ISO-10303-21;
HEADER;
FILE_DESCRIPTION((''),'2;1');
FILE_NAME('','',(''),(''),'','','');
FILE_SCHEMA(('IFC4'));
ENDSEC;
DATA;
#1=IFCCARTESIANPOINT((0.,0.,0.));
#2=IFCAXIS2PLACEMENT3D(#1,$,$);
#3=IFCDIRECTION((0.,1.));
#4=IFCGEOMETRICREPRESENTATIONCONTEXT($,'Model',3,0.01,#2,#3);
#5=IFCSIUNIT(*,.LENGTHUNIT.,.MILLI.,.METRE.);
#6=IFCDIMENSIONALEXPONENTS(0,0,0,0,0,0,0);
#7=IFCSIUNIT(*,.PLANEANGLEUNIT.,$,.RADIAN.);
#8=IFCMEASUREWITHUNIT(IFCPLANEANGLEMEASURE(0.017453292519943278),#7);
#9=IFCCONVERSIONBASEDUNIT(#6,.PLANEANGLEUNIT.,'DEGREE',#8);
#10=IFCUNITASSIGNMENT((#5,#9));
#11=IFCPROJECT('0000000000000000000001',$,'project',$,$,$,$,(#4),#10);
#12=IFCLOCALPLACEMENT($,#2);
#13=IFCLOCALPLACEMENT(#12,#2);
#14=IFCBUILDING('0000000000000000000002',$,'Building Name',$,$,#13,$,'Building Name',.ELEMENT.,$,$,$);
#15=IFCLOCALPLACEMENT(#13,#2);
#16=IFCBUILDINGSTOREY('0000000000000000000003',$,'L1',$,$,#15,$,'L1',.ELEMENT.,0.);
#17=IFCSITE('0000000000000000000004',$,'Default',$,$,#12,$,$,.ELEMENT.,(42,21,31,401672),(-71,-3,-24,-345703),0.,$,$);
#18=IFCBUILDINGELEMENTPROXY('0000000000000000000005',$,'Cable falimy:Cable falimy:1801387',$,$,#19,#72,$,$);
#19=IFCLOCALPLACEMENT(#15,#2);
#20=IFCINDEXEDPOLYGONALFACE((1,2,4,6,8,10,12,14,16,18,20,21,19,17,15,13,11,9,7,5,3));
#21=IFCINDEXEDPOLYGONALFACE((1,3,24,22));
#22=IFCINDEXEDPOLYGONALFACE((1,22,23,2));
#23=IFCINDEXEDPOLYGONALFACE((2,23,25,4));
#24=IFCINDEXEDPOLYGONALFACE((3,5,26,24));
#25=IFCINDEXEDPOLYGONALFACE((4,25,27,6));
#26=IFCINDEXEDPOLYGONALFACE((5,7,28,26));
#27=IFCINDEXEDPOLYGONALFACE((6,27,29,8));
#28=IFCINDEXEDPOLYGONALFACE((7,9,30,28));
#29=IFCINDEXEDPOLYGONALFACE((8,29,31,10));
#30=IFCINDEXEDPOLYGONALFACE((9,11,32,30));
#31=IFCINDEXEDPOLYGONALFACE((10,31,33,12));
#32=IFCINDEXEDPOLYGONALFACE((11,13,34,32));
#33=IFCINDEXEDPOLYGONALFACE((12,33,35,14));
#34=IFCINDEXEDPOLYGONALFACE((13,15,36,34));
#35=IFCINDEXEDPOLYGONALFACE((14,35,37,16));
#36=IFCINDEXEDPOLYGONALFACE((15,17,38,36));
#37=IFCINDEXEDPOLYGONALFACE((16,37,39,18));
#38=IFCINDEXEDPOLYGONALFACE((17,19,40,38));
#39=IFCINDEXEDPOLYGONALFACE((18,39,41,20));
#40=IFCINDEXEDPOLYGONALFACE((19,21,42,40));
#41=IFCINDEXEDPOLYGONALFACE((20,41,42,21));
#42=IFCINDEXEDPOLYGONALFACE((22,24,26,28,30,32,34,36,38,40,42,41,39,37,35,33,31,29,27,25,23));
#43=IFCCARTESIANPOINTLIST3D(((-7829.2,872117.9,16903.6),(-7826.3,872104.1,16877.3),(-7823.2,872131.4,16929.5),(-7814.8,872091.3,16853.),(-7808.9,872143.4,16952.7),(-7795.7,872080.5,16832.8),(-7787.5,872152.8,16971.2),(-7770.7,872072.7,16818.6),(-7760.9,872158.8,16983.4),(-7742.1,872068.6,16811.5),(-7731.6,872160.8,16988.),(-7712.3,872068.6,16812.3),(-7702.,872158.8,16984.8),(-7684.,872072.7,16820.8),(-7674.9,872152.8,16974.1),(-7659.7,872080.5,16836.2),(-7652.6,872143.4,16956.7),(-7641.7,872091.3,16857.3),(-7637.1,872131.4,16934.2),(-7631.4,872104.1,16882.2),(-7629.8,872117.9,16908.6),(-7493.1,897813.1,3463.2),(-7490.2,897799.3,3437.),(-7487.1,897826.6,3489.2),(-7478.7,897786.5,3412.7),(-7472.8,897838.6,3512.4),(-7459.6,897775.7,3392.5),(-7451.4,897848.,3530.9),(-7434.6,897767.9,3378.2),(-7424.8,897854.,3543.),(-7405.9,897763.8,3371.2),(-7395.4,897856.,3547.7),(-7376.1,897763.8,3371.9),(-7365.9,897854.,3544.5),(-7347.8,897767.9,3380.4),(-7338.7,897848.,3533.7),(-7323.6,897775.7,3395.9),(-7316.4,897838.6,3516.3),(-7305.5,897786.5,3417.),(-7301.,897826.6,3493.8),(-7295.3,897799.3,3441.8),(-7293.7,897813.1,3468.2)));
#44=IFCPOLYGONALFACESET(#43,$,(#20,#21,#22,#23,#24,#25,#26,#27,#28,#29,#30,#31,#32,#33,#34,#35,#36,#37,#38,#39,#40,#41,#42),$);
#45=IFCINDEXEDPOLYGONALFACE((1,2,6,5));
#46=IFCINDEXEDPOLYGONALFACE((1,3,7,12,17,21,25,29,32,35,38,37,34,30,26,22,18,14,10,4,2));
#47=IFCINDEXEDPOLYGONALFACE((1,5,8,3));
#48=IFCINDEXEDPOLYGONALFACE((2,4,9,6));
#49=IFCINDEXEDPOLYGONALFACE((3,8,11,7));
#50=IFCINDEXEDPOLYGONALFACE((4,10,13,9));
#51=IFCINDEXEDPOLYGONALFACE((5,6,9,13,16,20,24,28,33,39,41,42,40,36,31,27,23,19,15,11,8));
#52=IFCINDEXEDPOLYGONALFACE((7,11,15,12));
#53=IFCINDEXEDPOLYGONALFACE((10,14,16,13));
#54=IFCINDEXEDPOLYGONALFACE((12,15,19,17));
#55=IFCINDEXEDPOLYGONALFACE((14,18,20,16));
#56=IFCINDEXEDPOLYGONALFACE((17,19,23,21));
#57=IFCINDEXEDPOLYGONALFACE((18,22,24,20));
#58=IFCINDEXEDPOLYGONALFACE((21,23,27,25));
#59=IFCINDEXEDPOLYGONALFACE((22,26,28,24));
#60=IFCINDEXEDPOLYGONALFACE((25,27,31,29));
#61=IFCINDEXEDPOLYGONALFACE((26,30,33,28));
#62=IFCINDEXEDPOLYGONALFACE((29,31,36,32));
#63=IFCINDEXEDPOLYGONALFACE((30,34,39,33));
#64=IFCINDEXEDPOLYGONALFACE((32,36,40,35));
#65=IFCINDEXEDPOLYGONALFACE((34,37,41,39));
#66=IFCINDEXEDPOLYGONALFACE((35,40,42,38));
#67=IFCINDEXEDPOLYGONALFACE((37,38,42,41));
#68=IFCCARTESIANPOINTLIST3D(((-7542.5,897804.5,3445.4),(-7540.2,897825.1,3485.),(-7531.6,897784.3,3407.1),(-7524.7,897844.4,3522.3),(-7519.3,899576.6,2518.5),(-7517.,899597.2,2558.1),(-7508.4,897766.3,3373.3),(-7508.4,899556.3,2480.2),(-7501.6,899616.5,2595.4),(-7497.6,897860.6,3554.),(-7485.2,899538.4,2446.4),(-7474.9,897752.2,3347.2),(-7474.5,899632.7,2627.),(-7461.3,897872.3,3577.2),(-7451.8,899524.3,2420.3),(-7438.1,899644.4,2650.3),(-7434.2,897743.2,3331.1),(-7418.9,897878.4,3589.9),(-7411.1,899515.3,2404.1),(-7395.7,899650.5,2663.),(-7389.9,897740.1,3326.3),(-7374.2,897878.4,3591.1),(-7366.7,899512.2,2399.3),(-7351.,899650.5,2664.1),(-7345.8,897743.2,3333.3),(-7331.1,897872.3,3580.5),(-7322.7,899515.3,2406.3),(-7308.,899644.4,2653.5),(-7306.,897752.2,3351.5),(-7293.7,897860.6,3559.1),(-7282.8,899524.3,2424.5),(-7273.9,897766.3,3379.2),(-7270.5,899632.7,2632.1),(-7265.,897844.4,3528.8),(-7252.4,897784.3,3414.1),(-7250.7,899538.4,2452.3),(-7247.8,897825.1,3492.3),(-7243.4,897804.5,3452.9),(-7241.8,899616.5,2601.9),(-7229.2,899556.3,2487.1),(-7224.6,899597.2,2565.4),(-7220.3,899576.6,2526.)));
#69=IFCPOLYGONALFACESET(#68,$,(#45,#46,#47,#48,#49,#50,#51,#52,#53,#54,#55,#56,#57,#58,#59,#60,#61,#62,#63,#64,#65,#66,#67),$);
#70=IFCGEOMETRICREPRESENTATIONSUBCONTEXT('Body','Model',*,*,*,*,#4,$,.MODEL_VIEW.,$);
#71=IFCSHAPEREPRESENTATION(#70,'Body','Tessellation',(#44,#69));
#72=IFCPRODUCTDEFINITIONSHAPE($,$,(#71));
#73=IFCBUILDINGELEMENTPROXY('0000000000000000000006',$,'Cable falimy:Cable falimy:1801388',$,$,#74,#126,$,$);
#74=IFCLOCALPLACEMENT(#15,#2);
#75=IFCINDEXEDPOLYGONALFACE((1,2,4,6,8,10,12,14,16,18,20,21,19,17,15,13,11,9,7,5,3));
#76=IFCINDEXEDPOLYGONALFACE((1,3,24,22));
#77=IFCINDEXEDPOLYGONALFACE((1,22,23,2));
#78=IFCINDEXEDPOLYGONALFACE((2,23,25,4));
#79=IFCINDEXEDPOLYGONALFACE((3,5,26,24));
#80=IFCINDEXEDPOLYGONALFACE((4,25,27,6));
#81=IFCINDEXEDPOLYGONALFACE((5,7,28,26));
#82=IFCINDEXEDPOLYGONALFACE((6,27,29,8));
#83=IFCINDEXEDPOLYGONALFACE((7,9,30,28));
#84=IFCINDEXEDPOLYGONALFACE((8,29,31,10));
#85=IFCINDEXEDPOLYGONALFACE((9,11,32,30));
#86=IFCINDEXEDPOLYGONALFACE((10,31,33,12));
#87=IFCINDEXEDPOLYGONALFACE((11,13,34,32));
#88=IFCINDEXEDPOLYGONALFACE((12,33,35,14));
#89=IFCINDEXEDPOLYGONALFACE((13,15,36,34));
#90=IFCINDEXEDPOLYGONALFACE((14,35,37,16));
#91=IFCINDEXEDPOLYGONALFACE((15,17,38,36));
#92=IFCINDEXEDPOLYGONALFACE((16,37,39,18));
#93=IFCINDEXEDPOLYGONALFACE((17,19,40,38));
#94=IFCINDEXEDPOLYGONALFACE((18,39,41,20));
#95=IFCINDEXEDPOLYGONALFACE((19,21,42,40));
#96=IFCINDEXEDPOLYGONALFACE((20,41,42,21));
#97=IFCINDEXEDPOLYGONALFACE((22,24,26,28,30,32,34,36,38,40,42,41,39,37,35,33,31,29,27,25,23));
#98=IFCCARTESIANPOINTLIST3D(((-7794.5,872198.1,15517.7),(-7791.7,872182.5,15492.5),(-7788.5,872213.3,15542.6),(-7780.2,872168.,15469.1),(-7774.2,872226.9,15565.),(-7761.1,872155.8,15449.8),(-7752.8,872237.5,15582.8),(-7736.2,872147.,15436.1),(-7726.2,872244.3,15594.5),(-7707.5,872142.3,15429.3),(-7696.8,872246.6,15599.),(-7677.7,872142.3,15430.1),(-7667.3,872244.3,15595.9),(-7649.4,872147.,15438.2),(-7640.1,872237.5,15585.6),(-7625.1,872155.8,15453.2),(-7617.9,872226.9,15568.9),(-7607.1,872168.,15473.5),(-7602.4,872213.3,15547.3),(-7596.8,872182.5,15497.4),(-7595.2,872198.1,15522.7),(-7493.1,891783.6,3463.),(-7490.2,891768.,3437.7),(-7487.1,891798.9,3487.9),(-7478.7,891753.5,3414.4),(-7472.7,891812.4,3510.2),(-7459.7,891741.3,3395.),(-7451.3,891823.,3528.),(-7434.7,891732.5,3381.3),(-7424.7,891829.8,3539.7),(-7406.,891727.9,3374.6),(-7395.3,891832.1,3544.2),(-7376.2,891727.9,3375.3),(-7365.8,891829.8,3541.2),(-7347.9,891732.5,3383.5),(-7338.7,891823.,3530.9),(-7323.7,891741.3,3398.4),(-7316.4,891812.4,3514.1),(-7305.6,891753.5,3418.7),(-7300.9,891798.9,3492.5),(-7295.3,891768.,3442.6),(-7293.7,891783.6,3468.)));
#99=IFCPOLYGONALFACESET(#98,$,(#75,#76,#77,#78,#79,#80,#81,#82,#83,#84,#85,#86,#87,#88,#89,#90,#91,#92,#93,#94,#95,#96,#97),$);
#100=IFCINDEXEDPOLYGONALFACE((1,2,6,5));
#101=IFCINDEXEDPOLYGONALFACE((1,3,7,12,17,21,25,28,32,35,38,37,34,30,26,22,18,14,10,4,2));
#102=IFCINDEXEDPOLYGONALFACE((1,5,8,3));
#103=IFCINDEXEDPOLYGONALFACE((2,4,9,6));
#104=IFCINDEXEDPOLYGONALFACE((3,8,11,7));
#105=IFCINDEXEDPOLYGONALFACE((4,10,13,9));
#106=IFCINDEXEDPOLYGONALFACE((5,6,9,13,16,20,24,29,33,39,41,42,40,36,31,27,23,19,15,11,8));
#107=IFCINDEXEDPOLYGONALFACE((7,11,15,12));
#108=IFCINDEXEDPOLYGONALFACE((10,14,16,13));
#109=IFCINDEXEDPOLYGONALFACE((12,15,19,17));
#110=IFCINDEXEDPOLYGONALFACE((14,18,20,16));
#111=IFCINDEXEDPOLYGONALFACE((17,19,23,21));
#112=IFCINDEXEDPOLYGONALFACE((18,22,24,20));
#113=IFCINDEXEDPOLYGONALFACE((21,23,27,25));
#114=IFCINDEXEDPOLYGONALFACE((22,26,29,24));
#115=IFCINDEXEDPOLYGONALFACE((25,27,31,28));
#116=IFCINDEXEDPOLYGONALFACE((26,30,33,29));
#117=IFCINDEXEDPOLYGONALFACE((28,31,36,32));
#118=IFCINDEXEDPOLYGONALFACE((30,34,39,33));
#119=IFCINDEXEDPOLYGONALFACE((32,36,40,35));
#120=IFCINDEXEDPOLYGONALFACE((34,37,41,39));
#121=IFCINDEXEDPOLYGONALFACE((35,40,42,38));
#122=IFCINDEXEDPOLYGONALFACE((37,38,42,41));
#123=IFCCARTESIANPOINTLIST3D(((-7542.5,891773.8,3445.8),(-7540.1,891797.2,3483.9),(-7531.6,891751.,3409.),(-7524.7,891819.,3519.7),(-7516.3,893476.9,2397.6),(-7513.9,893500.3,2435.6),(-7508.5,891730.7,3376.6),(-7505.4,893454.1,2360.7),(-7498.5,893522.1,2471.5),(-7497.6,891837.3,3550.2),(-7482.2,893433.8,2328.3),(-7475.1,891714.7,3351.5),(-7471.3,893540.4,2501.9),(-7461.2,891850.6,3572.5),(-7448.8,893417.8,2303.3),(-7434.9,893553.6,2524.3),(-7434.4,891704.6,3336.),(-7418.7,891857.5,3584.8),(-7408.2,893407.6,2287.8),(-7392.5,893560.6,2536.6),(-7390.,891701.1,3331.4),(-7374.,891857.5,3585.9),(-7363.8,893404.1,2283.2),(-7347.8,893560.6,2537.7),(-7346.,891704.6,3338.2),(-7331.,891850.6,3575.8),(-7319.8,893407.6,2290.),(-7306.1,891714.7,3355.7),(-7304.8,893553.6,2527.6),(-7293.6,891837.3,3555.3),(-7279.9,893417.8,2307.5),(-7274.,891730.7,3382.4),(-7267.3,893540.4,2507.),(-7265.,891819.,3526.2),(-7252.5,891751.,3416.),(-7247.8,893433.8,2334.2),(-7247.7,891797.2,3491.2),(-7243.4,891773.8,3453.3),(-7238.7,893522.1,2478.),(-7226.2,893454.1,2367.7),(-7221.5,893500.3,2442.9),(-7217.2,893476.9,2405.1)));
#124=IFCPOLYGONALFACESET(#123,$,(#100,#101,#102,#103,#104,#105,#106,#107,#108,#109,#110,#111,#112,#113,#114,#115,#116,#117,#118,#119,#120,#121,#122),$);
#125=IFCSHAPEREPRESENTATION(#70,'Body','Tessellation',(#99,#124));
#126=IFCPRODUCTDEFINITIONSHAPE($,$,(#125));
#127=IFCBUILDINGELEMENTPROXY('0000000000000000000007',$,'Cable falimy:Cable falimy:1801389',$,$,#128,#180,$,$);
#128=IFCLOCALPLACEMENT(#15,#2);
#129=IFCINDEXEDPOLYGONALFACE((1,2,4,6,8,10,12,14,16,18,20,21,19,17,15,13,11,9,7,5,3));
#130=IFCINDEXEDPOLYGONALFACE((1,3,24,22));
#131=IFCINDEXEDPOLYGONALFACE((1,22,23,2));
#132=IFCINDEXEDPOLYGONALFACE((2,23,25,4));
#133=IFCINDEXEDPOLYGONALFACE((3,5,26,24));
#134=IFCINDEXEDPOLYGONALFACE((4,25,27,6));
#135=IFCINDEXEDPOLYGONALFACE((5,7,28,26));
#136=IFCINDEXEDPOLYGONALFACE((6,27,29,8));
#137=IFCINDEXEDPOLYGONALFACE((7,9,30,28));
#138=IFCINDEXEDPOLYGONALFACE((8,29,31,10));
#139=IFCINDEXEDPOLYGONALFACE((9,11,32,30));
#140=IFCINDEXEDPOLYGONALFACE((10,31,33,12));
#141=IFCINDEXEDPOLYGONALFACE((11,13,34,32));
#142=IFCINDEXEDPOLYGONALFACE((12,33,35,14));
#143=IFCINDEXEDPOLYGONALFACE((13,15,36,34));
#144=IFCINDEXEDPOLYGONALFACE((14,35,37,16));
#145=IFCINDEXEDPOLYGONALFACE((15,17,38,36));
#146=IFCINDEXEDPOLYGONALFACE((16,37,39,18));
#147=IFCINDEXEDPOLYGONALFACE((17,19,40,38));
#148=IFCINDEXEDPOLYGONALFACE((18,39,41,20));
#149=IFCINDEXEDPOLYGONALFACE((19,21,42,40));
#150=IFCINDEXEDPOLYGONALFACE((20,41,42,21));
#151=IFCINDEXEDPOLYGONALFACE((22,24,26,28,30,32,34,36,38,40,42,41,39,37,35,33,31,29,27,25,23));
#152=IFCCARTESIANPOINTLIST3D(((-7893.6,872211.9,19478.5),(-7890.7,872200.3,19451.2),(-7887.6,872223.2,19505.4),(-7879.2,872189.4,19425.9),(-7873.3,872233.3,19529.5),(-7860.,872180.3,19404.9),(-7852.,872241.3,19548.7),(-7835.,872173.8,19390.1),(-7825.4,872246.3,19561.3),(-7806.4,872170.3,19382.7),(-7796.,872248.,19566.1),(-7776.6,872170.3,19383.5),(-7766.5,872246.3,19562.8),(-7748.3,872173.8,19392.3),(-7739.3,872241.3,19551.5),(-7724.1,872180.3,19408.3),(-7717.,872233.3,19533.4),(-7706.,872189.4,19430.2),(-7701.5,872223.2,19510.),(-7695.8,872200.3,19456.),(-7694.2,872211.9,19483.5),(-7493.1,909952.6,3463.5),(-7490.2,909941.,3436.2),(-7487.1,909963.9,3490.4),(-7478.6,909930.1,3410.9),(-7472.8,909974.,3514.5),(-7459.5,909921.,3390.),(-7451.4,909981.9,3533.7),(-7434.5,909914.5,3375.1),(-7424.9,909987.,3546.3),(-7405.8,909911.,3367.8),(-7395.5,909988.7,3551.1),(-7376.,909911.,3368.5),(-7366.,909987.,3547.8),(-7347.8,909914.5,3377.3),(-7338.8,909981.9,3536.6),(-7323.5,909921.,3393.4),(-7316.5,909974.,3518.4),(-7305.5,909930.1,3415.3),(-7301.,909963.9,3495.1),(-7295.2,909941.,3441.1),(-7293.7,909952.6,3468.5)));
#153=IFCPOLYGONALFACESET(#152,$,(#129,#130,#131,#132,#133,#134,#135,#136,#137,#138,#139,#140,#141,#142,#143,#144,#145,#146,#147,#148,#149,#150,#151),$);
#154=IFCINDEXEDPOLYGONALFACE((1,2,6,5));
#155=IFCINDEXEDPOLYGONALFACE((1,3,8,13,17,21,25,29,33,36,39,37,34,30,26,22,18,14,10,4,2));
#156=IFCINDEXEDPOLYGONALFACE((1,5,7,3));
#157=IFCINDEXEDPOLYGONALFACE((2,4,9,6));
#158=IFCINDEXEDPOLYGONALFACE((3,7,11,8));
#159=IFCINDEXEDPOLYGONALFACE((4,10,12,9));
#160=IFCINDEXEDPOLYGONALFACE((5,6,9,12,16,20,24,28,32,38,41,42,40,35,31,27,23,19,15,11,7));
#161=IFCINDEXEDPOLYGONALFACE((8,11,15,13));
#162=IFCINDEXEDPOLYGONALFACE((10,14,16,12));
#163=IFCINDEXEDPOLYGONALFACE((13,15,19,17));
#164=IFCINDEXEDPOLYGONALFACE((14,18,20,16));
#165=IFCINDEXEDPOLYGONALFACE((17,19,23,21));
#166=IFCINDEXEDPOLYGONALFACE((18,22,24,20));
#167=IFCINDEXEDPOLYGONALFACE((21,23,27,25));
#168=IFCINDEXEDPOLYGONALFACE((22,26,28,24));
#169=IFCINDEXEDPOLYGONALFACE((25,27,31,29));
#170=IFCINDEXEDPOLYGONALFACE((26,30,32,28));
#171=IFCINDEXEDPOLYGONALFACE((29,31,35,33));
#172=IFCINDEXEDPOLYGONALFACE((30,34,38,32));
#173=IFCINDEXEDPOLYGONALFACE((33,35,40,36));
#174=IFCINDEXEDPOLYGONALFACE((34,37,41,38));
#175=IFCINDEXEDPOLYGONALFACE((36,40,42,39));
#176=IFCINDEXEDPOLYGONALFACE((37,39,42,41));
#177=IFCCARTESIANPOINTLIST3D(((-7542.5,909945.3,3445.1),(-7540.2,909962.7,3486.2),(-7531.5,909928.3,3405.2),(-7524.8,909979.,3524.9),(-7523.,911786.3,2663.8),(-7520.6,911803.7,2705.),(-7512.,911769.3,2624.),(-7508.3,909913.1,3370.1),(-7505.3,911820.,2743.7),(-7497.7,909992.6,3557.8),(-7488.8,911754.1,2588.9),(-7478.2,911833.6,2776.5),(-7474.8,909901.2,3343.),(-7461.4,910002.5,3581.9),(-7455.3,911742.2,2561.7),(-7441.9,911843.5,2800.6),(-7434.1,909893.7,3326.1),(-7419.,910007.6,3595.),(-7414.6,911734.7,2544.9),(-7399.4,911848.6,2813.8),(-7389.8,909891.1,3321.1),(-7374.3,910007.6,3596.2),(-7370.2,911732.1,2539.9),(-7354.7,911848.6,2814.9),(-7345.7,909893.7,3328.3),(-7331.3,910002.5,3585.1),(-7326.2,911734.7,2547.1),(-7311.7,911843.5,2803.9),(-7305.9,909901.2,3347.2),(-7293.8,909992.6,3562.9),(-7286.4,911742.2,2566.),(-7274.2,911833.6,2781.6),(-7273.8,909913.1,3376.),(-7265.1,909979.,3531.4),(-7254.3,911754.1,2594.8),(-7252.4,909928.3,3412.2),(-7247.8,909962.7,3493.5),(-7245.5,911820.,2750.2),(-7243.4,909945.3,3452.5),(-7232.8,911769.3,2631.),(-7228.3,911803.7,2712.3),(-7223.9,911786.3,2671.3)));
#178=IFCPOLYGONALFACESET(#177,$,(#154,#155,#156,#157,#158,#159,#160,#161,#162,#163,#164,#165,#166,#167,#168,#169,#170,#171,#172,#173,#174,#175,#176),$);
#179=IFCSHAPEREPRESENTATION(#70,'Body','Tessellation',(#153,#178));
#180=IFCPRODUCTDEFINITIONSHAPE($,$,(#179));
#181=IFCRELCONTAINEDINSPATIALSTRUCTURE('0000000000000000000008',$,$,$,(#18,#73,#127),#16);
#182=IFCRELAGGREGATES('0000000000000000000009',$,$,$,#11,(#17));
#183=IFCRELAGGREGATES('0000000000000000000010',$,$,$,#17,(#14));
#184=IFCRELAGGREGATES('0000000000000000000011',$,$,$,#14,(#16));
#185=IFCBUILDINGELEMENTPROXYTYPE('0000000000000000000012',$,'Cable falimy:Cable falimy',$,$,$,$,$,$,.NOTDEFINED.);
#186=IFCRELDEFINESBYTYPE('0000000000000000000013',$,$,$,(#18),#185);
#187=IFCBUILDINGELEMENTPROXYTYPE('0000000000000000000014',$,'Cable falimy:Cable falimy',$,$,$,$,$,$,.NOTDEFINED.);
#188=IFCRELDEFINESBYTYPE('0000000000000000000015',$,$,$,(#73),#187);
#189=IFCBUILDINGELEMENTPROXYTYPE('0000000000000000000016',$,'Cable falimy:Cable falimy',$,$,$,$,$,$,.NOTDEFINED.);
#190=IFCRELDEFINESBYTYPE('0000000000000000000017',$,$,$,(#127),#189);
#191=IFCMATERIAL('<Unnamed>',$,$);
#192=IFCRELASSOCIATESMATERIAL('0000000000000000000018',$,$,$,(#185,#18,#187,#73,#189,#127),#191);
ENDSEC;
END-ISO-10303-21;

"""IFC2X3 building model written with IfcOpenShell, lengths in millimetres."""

from ifc_helpers import new_model, entity, si_unit, converted_unit, direction, frame, frame_2d, origin, place, context, subcontext, project, spatial, circle, extrude, source, transform, mapped, material, type_object, type_shapes, element, save


model = new_model("IFC2X3")

# Units and contexts
model_context = context("Model", 3, precision=0.01, world=origin(), true_north=direction((0.0, 1.0)))
body_context = subcontext(model_context, "Body", "Model", "MODEL_VIEW")
ifc_project = project(units=[si_unit("LENGTHUNIT", "METRE", prefix="MILLI"), converted_unit("PLANEANGLEUNIT", "DEGREE", entity("IfcPlaneAngleMeasure", 0.017453292519943278), si_unit("PLANEANGLEUNIT", "RADIAN"), dimensions=[0, 0, 0, 0, 0, 0, 0])], contexts=[model_context])

# Site, building, storey
site_placement = place(None, origin())
site = spatial("IfcSite", under=ifc_project, at=site_placement, Name="Default", CompositionType="ELEMENT", RefLatitude=(42, 21, 31, 401672), RefLongitude=(-71, -3, -24, -345703), RefElevation=0.0)
building_placement = place(site_placement, origin())
building = spatial("IfcBuilding", under=site, at=building_placement, Name="Building Name", LongName="Building Name", CompositionType="ELEMENT")
storey_placement = place(building_placement, origin())
storey = spatial("IfcBuildingStorey", under=building, at=storey_placement, Name="L1", LongName="L1", CompositionType="ELEMENT", Elevation=0.0)

# Shared definitions
ifc_material = material(Name="<Unnamed>")

# Building element proxies
building_element_proxy_type_1 = type_object("IfcBuildingElementProxyType", Name="Cable falimy:Cable falimy", PredefinedType="NOTDEFINED", material=ifc_material)
shared_shape_1 = source(origin(), body_context, "Body", "SweptSolid", [
    extrude(circle(Radius=100.0, at=frame_2d((0.0, 0.0), x_axis=(1.0, 0.0))), frame((0.0, 0.0, 0.0), z_axis=(0.886042, 0.0, 0.463605), x_axis=(-0.463605, 0.0, 0.886042)), (0.0, 0.0, 1.0), 29000.0),
    extrude(circle(Radius=150.0, at=frame_2d((0.0, 0.0), x_axis=(1.0, 0.0))), frame((-1772.1, 0.0, -927.2), z_axis=(0.886042, 0.0, 0.463605), x_axis=(0.463605, 0.0, -0.886042)), (0.0, 0.0, 1.0), 2000.0),
])
type_shapes(building_element_proxy_type_1, [shared_shape_1])
proxy_1_placement = place(storey_placement, frame((-7393.2, 897809.7, 3459.1), z_axis=(-0.025001, 0.0, 0.999687), x_axis=(0.0, -1.0, 0.0)))
element("IfcBuildingElementProxy", 1, at=proxy_1_placement, inside=storey, type_object=building_element_proxy_type_1, material=ifc_material, Name="Cable falimy:Cable falimy:1801387", context=body_context, shape_type="MappedRepresentation", body=[
    mapped(shared_shape_1, transform((0.0, 0.0, 0.0), scale=1.0)),
])
building_element_proxy_type_2 = type_object("IfcBuildingElementProxyType", Name="Cable falimy:Cable falimy", PredefinedType="NOTDEFINED", material=ifc_material)
shared_shape_2 = source(origin(), body_context, "Body", "SweptSolid", [
    extrude(circle(Radius=100.0, at=frame_2d((0.0, 0.0), x_axis=(1.0, 0.0))), frame((0.0, 0.0, 0.0), z_axis=(0.851544, 0.0, 0.524283), x_axis=(-0.524283, 0.0, 0.851544)), (0.0, 0.0, 1.0), 23000.0),
    extrude(circle(Radius=150.0, at=frame_2d((0.0, 0.0), x_axis=(1.0, 0.0))), frame((-1703.1, 0.0, -1048.6), z_axis=(0.851544, 0.0, 0.524283), x_axis=(0.524283, 0.0, -0.851544)), (0.0, 0.0, 1.0), 2000.0),
])
type_shapes(building_element_proxy_type_2, [shared_shape_2])
proxy_2_placement = place(storey_placement, frame((-7393.2, 891779.7, 3459.1), z_axis=(-0.025001, 0.0, 0.999687), x_axis=(0.0, -1.0, 0.0)))
element("IfcBuildingElementProxy", 2, at=proxy_2_placement, inside=storey, type_object=building_element_proxy_type_2, material=ifc_material, Name="Cable falimy:Cable falimy:1801388", context=body_context, shape_type="MappedRepresentation", body=[
    mapped(shared_shape_2, transform((0.0, 0.0, 0.0), scale=1.0)),
])
building_element_proxy_type_3 = type_object("IfcBuildingElementProxyType", Name="Cable falimy:Cable falimy", PredefinedType="NOTDEFINED", material=ifc_material)
shared_shape_3 = source(origin(), body_context, "Body", "SweptSolid", [
    extrude(circle(Radius=100.0, at=frame_2d((0.0, 0.0), x_axis=(1.0, 0.0))), frame((0.0, 0.0, 0.0), z_axis=(0.920505, 0.0, 0.390731), x_axis=(-0.390731, 0.0, 0.920505)), (0.0, 0.0, 1.0), 41000.0),
    extrude(circle(Radius=150.0, at=frame_2d((0.0, 0.0), x_axis=(1.0, 0.0))), frame((-1841.0, 0.0, -781.5), z_axis=(0.920505, 0.0, 0.390731), x_axis=(0.390731, 0.0, -0.920505)), (0.0, 0.0, 1.0), 2000.0),
])
type_shapes(building_element_proxy_type_3, [shared_shape_3])
proxy_3_placement = place(storey_placement, frame((-7393.2, 909949.7, 3459.1), z_axis=(-0.025001, 0.0, 0.999687), x_axis=(0.0, -1.0, 0.0)))
element("IfcBuildingElementProxy", 3, at=proxy_3_placement, inside=storey, type_object=building_element_proxy_type_3, material=ifc_material, Name="Cable falimy:Cable falimy:1801389", context=body_context, shape_type="MappedRepresentation", body=[
    mapped(shared_shape_3, transform((0.0, 0.0, 0.0), scale=1.0)),
])

save(model, "model.ifc")
